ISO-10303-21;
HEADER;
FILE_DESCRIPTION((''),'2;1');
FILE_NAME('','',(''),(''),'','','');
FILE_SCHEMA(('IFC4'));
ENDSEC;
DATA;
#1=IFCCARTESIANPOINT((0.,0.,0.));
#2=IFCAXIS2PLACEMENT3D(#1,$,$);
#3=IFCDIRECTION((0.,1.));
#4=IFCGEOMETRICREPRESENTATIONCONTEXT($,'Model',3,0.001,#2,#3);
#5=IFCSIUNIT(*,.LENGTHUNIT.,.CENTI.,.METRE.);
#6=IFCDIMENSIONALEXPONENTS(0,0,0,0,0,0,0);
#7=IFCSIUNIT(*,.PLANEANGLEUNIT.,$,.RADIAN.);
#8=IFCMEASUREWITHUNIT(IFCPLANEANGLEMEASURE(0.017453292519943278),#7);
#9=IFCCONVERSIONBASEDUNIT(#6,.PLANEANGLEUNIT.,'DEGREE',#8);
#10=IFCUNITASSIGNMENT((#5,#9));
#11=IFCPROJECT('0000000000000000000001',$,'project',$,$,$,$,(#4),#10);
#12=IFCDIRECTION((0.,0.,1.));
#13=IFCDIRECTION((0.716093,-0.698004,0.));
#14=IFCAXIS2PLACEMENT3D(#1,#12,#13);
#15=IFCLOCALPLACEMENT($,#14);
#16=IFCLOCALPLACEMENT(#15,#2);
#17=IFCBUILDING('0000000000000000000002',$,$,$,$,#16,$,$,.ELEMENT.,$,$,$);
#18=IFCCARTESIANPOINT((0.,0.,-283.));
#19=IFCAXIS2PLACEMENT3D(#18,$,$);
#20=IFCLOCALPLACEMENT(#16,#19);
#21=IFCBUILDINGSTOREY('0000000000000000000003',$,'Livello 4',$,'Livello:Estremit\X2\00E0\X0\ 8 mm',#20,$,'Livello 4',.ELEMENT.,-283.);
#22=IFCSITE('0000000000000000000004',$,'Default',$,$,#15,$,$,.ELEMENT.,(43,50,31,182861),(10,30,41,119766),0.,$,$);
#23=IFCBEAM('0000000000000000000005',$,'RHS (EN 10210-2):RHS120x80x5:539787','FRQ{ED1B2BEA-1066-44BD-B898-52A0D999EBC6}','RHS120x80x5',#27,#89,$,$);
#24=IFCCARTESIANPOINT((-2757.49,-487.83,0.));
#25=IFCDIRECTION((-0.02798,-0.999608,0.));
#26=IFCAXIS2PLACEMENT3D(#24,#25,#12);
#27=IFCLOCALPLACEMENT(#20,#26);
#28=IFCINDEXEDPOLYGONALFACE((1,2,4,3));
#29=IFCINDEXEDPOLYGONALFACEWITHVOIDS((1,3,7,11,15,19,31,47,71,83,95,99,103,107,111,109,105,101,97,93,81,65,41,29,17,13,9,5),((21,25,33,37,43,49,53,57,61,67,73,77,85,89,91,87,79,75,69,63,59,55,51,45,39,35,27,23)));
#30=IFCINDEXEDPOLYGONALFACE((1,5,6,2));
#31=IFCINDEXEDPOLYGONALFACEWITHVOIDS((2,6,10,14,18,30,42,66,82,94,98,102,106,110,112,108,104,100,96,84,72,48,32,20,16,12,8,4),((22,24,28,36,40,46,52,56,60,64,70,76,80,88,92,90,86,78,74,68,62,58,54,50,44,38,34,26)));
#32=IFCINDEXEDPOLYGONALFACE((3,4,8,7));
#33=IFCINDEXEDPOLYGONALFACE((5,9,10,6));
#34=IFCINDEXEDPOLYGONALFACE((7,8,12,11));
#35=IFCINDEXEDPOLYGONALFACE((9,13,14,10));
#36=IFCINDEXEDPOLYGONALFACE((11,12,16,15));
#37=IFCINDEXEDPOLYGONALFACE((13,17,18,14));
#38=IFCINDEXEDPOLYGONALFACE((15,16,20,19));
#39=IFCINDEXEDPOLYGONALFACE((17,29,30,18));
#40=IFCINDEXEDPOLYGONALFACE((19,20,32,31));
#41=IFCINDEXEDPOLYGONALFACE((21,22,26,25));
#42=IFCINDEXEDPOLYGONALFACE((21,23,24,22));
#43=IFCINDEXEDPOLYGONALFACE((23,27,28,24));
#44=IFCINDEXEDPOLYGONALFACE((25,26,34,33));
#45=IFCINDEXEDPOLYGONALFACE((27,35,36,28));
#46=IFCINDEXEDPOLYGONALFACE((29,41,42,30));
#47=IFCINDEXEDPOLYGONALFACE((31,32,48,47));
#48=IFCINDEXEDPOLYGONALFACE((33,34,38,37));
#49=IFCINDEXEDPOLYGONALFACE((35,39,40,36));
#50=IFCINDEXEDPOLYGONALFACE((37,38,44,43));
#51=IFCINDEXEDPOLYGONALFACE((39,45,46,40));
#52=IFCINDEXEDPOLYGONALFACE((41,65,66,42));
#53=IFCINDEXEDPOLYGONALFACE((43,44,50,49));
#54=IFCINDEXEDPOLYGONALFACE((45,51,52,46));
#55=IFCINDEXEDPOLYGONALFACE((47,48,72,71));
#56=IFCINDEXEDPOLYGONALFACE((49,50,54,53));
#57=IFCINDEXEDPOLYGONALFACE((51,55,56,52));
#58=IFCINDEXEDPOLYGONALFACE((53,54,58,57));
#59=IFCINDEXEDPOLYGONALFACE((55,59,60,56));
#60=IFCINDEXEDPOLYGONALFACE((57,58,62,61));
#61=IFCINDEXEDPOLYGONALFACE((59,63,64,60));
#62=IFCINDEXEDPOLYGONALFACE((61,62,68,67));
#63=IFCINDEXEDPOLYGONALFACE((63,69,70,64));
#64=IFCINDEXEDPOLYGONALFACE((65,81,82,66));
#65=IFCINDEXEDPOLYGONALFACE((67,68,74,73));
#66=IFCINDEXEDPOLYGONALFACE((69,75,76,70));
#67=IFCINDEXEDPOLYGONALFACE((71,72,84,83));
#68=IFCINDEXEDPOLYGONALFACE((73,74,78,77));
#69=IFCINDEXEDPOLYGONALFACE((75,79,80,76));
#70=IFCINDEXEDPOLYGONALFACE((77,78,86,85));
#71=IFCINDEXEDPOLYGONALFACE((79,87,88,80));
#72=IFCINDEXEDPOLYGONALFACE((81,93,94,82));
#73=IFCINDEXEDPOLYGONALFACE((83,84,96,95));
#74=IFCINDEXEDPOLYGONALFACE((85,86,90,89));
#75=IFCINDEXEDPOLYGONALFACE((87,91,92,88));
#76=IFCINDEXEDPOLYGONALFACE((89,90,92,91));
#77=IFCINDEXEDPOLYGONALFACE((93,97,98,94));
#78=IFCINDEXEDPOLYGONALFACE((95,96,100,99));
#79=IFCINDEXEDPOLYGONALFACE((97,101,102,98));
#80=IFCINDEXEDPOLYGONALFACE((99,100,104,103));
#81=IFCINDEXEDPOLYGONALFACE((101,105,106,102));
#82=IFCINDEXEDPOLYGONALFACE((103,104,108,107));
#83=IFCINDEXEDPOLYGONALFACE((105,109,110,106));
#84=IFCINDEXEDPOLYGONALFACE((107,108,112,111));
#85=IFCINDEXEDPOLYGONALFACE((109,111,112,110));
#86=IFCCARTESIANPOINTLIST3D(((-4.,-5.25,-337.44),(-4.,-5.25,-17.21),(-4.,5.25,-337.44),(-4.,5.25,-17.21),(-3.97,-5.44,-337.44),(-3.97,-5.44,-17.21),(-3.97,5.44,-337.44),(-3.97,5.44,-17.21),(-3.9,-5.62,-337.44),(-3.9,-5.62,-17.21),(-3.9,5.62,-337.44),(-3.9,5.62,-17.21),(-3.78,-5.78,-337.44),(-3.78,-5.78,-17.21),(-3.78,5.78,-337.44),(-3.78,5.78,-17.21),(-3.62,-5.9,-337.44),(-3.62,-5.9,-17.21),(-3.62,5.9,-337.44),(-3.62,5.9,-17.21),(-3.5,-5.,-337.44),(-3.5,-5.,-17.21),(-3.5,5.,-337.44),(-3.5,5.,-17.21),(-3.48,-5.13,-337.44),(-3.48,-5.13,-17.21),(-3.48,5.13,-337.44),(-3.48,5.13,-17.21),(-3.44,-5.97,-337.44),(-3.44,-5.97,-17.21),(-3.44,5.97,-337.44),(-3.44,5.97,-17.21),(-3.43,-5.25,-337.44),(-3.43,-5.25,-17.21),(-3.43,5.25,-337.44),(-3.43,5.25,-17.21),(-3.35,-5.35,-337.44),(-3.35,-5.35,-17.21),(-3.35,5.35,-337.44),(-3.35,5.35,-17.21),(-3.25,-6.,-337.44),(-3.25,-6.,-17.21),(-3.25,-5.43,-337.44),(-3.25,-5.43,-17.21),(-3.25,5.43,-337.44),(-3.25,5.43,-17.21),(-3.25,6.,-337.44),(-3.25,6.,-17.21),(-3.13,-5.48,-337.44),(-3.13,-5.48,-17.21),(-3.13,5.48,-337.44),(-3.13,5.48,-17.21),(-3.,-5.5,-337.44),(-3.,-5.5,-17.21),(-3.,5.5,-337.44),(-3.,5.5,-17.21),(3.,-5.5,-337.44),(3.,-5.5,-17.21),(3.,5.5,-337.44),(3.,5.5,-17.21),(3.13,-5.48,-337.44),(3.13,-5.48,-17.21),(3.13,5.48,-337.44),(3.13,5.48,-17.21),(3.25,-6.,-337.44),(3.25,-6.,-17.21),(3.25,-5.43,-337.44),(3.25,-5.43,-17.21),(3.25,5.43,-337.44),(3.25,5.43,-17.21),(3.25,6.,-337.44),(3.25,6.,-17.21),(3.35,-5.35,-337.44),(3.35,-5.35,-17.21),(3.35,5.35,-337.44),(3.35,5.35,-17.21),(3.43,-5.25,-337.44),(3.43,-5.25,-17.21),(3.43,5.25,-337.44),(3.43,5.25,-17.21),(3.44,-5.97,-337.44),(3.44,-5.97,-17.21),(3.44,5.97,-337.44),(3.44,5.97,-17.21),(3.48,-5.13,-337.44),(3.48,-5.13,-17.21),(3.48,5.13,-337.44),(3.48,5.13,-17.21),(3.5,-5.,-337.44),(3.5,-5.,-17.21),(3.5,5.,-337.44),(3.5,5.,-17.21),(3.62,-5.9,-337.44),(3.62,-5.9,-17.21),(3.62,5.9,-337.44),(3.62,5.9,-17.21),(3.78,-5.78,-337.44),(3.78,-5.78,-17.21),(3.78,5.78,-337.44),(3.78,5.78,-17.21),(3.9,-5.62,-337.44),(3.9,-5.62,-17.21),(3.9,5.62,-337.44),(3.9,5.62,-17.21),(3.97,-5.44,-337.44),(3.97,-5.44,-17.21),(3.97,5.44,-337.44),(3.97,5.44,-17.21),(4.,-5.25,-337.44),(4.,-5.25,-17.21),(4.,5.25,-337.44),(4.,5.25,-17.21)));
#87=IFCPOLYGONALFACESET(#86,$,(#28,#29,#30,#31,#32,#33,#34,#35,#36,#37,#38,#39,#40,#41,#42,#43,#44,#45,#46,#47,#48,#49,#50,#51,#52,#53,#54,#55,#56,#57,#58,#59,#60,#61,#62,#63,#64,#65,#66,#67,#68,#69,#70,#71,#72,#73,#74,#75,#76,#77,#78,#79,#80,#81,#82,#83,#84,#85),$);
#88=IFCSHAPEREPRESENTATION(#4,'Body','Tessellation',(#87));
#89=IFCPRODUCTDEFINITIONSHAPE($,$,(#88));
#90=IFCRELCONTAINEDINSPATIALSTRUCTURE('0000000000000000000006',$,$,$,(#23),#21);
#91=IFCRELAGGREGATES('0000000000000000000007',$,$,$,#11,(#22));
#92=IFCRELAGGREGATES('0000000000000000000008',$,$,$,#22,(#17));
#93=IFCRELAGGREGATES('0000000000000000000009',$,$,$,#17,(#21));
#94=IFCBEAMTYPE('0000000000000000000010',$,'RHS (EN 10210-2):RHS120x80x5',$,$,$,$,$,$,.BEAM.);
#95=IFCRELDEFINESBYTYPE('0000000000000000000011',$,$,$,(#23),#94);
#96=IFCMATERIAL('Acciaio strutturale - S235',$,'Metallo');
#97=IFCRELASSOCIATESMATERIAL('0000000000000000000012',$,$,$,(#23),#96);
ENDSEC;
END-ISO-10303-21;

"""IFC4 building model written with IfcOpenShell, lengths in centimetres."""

from ifc_helpers import new_model, entity, si_unit, converted_unit, direction, frame, origin, origin_2d, place, context, project, spatial, hollow_rectangle, extrude, clip, halfspace, material, type_object, element, save


model = new_model("IFC4")

# Units and contexts
model_context = context("Model", 3, precision=0.001, world=origin(), true_north=direction((0.0, 1.0)))
ifc_project = project(units=[si_unit("LENGTHUNIT", "METRE", prefix="CENTI"), converted_unit("PLANEANGLEUNIT", "DEGREE", entity("IfcPlaneAngleMeasure", 0.017453292519943278), si_unit("PLANEANGLEUNIT", "RADIAN"), dimensions=[0, 0, 0, 0, 0, 0, 0])], contexts=[model_context])

# Site, building, storey
site_placement = place(None, frame((0.0, 0.0, 0.0), z_axis=(0.0, 0.0, 1.0), x_axis=(0.716093, -0.698004, 0.0)))
site = spatial("IfcSite", under=ifc_project, at=site_placement, Name="Default", CompositionType="ELEMENT", RefLatitude=(43, 50, 31, 182861), RefLongitude=(10, 30, 41, 119766), RefElevation=0.0)
building_placement = place(site_placement, origin())
building = spatial("IfcBuilding", under=site, at=building_placement, CompositionType="ELEMENT")
storey_placement = place(building_placement, frame((0.0, 0.0, -283.0)))
storey = spatial("IfcBuildingStorey", under=building, at=storey_placement, Name="Livello 4", ObjectType="Livello:Estremità 8 mm", LongName="Livello 4", CompositionType="ELEMENT", Elevation=-283.0)

# Shared definitions
ifc_material = material(Name="Acciaio strutturale - S235", Category="Metallo")

# Shared definitions
beam_type = type_object("IfcBeamType", Name="RHS (EN 10210-2):RHS120x80x5", PredefinedType="BEAM")

# Beam
beam_1_placement = place(storey_placement, frame((-2757.49, -487.83, 0.0), z_axis=(-0.02798, -0.999608, 0.0), x_axis=(0.0, 0.0, 1.0)))
element("IfcBeam", 1, at=beam_1_placement, inside=storey, type_object=beam_type, material=ifc_material, Name="RHS (EN 10210-2):RHS120x80x5:539787", Description="FRQ{ED1B2BEA-1066-44BD-B898-52A0D999EBC6}", ObjectType="RHS120x80x5", context=model_context, shape_type="Clipping", body=[
    clip(extrude(hollow_rectangle(XDim=8.0, YDim=12.0, WallThickness=0.5, InnerFilletRadius=0.5, OuterFilletRadius=0.75, at=origin_2d()), origin(), (0.0, 0.0, -1.0), 337.44), halfspace(frame((283.0, -2742.76, -17.21), z_axis=(0.0, 0.0, -1.0), x_axis=(0.0, 1.0, 0.0)), True)),
])

save(model, "model.ifc")
